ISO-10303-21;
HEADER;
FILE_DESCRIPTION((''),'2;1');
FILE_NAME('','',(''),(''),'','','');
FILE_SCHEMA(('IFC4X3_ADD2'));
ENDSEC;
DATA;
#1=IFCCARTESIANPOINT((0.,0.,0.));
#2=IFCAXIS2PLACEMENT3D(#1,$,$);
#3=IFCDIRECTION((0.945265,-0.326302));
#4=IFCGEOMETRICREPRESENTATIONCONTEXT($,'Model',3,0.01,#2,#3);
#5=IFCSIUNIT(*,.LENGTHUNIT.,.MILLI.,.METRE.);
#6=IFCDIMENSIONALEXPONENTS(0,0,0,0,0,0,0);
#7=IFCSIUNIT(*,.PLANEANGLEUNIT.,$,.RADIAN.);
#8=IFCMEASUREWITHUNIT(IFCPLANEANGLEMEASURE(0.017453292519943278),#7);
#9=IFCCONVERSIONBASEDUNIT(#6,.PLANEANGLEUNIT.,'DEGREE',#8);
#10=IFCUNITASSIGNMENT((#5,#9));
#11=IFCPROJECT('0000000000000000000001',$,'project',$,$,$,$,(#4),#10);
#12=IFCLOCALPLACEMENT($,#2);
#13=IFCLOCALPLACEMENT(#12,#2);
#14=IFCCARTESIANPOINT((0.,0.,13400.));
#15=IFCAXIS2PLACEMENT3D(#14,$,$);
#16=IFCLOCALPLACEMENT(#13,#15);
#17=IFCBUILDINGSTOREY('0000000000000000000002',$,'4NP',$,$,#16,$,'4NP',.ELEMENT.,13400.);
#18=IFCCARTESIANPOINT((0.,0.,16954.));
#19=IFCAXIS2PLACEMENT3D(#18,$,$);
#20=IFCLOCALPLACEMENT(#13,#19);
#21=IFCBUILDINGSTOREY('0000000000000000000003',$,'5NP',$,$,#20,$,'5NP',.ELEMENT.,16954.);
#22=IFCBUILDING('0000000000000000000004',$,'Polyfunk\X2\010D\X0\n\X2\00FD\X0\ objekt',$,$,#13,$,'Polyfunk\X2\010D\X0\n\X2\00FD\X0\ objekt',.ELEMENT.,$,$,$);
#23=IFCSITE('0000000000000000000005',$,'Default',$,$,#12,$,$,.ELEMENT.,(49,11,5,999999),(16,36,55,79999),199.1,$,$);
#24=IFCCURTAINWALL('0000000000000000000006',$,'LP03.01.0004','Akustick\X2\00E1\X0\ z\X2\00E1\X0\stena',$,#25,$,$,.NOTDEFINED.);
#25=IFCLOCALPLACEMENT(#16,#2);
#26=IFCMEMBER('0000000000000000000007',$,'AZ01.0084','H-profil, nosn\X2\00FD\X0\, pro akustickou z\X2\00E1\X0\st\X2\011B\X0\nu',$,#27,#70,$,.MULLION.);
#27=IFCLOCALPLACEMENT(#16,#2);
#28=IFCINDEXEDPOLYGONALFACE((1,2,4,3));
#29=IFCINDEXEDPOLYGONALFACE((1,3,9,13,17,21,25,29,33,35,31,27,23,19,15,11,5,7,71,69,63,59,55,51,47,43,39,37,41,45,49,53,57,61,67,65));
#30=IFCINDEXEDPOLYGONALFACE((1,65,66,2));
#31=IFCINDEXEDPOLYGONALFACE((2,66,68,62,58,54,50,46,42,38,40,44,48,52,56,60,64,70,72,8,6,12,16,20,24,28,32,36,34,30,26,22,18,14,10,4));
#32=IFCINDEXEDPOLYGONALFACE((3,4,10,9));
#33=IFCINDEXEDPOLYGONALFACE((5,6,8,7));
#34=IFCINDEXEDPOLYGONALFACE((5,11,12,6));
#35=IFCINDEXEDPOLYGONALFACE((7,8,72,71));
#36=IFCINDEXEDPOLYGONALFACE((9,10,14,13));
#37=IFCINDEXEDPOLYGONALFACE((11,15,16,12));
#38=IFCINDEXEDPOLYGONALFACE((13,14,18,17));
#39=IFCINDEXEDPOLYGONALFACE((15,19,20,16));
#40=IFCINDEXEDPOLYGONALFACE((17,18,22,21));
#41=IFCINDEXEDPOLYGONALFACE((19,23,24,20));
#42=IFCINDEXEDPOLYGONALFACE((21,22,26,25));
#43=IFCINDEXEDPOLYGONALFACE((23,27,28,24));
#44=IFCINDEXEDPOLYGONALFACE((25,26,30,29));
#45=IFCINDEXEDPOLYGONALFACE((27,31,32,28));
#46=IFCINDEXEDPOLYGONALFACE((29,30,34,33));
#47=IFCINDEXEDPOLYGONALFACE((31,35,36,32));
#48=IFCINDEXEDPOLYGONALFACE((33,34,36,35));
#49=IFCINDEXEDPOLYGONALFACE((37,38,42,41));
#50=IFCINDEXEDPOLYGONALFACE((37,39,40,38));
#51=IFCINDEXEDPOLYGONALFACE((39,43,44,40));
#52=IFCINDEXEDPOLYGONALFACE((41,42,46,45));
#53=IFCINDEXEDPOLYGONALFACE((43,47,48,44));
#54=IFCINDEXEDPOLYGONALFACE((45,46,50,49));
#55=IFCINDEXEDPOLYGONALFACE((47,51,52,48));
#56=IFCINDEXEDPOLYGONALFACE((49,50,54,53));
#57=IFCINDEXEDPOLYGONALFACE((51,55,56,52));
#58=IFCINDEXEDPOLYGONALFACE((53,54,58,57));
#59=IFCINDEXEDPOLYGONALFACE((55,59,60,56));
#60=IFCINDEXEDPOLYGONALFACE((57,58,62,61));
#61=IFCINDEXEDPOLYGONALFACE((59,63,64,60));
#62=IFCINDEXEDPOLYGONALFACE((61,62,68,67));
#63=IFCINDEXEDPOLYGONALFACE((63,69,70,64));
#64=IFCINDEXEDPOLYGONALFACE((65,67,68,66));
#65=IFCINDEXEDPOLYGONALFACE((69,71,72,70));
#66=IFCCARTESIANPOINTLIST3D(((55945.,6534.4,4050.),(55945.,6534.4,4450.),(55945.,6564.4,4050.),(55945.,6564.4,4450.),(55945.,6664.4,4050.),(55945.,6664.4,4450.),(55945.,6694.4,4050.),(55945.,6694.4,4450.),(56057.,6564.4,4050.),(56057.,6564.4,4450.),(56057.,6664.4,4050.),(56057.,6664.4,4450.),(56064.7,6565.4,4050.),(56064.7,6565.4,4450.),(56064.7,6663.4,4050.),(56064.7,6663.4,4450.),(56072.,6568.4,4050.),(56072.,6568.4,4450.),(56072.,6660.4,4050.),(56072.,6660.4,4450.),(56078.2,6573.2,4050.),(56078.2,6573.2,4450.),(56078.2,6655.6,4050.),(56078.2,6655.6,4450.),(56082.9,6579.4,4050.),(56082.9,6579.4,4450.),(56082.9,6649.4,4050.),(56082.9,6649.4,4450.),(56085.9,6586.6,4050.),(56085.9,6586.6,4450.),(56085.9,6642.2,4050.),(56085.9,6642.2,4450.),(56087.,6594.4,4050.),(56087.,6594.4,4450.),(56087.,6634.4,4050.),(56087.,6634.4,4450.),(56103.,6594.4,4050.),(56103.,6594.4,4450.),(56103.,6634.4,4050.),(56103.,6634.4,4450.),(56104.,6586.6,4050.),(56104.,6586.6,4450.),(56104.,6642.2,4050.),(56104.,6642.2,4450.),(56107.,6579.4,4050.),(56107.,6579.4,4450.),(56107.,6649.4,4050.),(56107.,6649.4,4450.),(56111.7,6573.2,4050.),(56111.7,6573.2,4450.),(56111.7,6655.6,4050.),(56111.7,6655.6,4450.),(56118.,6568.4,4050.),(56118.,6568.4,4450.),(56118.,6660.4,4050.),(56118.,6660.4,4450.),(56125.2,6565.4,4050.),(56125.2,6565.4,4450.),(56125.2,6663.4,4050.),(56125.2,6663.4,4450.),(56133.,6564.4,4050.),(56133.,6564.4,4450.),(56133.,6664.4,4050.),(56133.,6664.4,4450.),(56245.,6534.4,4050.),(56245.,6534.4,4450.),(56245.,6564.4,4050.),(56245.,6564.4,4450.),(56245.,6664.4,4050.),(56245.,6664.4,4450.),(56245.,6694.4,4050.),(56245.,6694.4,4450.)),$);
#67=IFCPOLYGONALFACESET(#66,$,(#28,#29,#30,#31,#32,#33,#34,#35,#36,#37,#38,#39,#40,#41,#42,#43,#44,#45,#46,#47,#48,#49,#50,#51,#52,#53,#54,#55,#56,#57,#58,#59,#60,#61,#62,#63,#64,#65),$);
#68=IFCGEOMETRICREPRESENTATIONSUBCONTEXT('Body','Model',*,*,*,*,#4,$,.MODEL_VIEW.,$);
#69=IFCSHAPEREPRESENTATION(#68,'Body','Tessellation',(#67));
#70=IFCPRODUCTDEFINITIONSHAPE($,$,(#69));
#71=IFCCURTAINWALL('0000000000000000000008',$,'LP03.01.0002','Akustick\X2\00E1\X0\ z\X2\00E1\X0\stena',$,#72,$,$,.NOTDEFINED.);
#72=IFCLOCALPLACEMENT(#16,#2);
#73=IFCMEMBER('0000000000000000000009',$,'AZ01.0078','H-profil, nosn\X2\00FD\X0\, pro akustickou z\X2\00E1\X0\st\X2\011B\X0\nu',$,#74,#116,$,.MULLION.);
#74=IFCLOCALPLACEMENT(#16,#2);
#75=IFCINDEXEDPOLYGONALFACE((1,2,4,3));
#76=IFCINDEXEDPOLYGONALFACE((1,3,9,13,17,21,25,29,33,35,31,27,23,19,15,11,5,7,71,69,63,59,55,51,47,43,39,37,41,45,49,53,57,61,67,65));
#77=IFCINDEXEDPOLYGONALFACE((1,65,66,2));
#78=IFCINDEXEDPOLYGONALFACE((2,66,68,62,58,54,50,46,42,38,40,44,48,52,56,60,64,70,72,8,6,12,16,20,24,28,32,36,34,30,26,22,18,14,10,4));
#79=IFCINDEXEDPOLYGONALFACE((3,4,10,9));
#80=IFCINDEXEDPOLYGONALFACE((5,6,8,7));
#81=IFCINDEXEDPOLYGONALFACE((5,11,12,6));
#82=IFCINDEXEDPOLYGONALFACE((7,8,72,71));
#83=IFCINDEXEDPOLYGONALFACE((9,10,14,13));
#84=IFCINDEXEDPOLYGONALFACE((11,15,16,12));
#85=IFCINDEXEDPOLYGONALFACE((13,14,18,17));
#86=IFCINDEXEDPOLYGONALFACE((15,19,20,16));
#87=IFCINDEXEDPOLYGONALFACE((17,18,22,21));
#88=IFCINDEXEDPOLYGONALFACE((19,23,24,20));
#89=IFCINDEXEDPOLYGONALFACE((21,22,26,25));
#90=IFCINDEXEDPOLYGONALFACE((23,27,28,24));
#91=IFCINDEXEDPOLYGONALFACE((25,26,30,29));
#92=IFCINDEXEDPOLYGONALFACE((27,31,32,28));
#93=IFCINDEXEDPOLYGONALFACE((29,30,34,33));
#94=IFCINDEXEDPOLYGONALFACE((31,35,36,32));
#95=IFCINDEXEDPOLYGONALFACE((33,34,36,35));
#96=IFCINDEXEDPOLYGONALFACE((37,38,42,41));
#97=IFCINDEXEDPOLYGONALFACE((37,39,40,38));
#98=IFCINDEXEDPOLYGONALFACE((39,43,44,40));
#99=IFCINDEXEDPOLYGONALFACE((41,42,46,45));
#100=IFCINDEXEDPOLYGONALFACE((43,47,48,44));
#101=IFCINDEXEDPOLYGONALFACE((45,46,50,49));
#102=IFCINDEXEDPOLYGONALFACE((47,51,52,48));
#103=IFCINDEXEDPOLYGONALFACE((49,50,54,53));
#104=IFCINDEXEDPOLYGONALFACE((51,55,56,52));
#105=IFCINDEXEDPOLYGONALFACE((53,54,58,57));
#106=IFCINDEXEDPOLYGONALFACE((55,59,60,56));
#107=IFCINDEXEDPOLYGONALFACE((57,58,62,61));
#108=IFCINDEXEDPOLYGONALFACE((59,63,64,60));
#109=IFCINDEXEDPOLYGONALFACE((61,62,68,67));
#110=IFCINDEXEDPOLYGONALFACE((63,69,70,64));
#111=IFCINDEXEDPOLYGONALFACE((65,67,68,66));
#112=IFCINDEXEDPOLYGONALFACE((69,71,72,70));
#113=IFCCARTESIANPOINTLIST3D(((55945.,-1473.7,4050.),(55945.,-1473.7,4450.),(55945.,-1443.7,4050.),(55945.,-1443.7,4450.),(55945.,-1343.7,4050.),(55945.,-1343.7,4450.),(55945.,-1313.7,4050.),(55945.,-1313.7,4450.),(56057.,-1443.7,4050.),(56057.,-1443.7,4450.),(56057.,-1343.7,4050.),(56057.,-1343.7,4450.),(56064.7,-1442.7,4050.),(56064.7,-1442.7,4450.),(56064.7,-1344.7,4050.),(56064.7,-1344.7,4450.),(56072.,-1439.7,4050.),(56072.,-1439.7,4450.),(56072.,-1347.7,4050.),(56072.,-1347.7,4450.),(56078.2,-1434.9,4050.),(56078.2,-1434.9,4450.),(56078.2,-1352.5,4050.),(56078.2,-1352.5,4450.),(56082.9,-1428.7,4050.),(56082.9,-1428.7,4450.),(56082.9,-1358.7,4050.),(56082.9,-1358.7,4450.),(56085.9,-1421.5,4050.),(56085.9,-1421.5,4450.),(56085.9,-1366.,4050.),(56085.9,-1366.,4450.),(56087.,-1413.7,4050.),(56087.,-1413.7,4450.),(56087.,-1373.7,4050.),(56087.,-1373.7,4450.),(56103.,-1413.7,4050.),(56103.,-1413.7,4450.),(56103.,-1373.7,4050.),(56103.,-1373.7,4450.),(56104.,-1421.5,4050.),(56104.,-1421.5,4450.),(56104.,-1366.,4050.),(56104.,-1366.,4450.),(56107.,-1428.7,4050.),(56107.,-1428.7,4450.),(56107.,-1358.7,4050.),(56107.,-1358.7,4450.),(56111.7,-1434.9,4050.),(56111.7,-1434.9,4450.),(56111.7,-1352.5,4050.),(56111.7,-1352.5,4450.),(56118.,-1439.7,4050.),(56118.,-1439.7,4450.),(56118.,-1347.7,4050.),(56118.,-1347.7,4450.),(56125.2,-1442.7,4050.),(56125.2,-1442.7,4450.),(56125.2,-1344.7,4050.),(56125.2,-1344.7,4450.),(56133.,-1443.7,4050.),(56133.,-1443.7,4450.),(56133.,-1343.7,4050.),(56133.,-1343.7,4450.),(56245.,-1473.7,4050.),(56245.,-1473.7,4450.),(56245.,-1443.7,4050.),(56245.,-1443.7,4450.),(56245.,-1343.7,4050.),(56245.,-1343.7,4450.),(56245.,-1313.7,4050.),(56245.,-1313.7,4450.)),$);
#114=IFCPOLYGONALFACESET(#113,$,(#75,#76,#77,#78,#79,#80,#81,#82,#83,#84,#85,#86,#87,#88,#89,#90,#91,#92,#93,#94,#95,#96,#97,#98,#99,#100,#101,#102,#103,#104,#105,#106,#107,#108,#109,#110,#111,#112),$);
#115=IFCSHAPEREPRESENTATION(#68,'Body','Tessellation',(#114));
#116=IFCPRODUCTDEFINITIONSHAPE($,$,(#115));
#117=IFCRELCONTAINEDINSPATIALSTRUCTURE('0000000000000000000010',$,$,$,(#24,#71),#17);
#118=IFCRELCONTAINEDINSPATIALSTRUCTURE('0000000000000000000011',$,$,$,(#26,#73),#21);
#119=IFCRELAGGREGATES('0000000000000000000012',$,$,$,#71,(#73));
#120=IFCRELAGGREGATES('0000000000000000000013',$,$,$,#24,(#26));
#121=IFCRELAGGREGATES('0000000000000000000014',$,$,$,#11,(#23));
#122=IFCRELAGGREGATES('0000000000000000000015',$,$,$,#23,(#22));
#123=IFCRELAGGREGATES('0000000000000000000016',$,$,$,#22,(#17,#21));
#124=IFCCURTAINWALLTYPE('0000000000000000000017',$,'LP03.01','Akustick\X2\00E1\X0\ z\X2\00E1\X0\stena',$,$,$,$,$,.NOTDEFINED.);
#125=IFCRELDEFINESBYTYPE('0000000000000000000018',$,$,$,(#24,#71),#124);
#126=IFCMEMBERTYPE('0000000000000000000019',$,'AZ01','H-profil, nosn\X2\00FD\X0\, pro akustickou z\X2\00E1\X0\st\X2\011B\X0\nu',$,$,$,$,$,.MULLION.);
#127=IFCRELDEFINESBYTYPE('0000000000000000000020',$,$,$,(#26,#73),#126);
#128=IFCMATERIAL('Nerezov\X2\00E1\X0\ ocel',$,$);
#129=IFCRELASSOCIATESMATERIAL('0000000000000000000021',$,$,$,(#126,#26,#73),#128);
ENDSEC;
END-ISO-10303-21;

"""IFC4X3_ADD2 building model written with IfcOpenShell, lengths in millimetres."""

from ifc_helpers import new_model, entity, si_unit, converted_unit, direction, frame, frame_2d, origin, place, context, subcontext, project, spatial, polyline, circle_curve, parameter, trimmed, segment, composite_curve, outline, extrude, source, transform, mapped, material, material_profile, profile_set, profile_usage, type_object, element, aggregate, save


model = new_model("IFC4X3_ADD2")

# Units and contexts
model_context = context("Model", 3, precision=0.01, world=origin(), true_north=direction((0.945265, -0.326302)))
body_context = subcontext(model_context, "Body", "Model", "MODEL_VIEW")
ifc_project = project(units=[si_unit("LENGTHUNIT", "METRE", prefix="MILLI"), converted_unit("PLANEANGLEUNIT", "DEGREE", entity("IfcPlaneAngleMeasure", 0.017453292519943278), si_unit("PLANEANGLEUNIT", "RADIAN"), dimensions=[0, 0, 0, 0, 0, 0, 0])], contexts=[model_context])

# Site, building, storey
site_placement = place(None, origin())
site = spatial("IfcSite", under=ifc_project, at=site_placement, Name="Default", CompositionType="ELEMENT", RefLatitude=(49, 11, 5, 999999), RefLongitude=(16, 36, 55, 79999), RefElevation=199.1)
building_placement = place(site_placement, origin())
building = spatial("IfcBuilding", under=site, at=building_placement, Name="Polyfunkčný objekt", LongName="Polyfunkčný objekt", CompositionType="ELEMENT")
storey_1_placement = place(building_placement, frame((0.0, 0.0, 13400.0)))
storey_1 = spatial("IfcBuildingStorey", under=building, at=storey_1_placement, Name="4NP", LongName="4NP", CompositionType="ELEMENT", Elevation=13400.0)

# Curtain wall
curtain_wall_type = type_object("IfcCurtainWallType", Name="LP03.01", Description="Akustická zástena", PredefinedType="NOTDEFINED")
curtain_wall_1_placement = place(storey_1_placement, frame((0.0, 0.0, -13400.0)))
curtain_wall_1 = element("IfcCurtainWall", 1, at=curtain_wall_1_placement, inside=storey_1, type_object=curtain_wall_type, Name="LP03.01.0004", Description="Akustická zástena", PredefinedType="NOTDEFINED")

# Shared definitions
storey_2_placement = place(building_placement, frame((0.0, 0.0, 16954.0)))
storey_2 = spatial("IfcBuildingStorey", under=building, at=storey_2_placement, Name="5NP", LongName="5NP", CompositionType="ELEMENT", Elevation=16954.0)

# Shared definitions
ifc_material_1 = material(Name="Nerezová ocel")
ifc_material_profile = material_profile(ifc_material_1, outline(composite_curve([segment(polyline([(50.0, -150.0), (80.0, -150.0)]), True, "CONTINUOUS"), segment(polyline([(80.0, -150.0), (80.0, 150.0)]), True, "CONTINUOUS"), segment(polyline([(80.0, 150.0), (50.0, 150.0)]), True, "CONTINUOUS"), segment(polyline([(50.0, 150.0), (50.0, 38.0)]), True, "CONTINUOUS"), segment(trimmed(circle_curve(frame_2d((20.0, 38.0), x_axis=(0.0, 1.0)), 30.0), [parameter(180.0)], [parameter(270.0)], True, "PARAMETER"), False, "CONTINUOUS"), segment(polyline([(20.0, 8.0), (-20.0, 8.0)]), True, "CONTINUOUS"), segment(trimmed(circle_curve(frame_2d((-20.0, 38.0), x_axis=(0.0, 1.0)), 30.0), [parameter(90.0)], [parameter(180.0)], True, "PARAMETER"), False, "CONTINUOUS"), segment(polyline([(-50.0, 38.0), (-50.0, 150.0)]), True, "CONTINUOUS"), segment(polyline([(-50.0, 150.0), (-80.0, 150.0)]), True, "CONTINUOUS"), segment(polyline([(-80.0, 150.0), (-80.0, -150.0)]), True, "CONTINUOUS"), segment(polyline([(-80.0, -150.0), (-50.0, -150.0)]), True, "CONTINUOUS"), segment(polyline([(-50.0, -150.0), (-50.0, -38.0)]), True, "CONTINUOUS"), segment(trimmed(circle_curve(frame_2d((-20.0, -38.0), x_axis=(0.0, 1.0)), 30.0), [parameter(0.0)], [parameter(90.0)], True, "PARAMETER"), False, "CONTINUOUS"), segment(polyline([(-20.0, -8.0), (20.0, -8.0)]), True, "CONTINUOUS"), segment(trimmed(circle_curve(frame_2d((20.0, -38.0), x_axis=(0.0, 1.0)), 30.0), [parameter(270.0)], [parameter(0.0)], True, "PARAMETER"), False, "CONTINUOUS"), segment(polyline([(50.0, -38.0), (50.0, -150.0)]), True, "CONTINUOUS")], self_intersect=False)), Name="Profil zástena")
ifc_profile_set = profile_set([ifc_material_profile], Name="Profil zástena")
ifc_profile_usage = profile_usage(ifc_profile_set)
member_type = type_object("IfcMemberType", Name="AZ01", Description="H-profil, nosný, pro akustickou zástěnu", PredefinedType="MULLION", material=ifc_profile_set)

# Member
shared_shape_1 = source(origin(), body_context, "Body", "SweptSolid", [
    extrude(outline(composite_curve([segment(polyline([(50.0, -150.0), (80.0, -150.0)]), True, "CONTINUOUS"), segment(polyline([(80.0, -150.0), (80.0, 150.0)]), True, "CONTINUOUS"), segment(polyline([(80.0, 150.0), (50.0, 150.0)]), True, "CONTINUOUS"), segment(polyline([(50.0, 150.0), (50.0, 38.0)]), True, "CONTINUOUS"), segment(trimmed(circle_curve(frame_2d((20.0, 38.0), x_axis=(0.0, 1.0)), 30.0), [parameter(180.0)], [parameter(270.0)], True, "PARAMETER"), False, "CONTINUOUS"), segment(polyline([(20.0, 8.0), (-20.0, 8.0)]), True, "CONTINUOUS"), segment(trimmed(circle_curve(frame_2d((-20.0, 38.0), x_axis=(0.0, 1.0)), 30.0), [parameter(90.0)], [parameter(180.0)], True, "PARAMETER"), False, "CONTINUOUS"), segment(polyline([(-50.0, 38.0), (-50.0, 150.0)]), True, "CONTINUOUS"), segment(polyline([(-50.0, 150.0), (-80.0, 150.0)]), True, "CONTINUOUS"), segment(polyline([(-80.0, 150.0), (-80.0, -150.0)]), True, "CONTINUOUS"), segment(polyline([(-80.0, -150.0), (-50.0, -150.0)]), True, "CONTINUOUS"), segment(polyline([(-50.0, -150.0), (-50.0, -38.0)]), True, "CONTINUOUS"), segment(trimmed(circle_curve(frame_2d((-20.0, -38.0), x_axis=(0.0, 1.0)), 30.0), [parameter(0.0)], [parameter(90.0)], True, "PARAMETER"), False, "CONTINUOUS"), segment(polyline([(-20.0, -8.0), (20.0, -8.0)]), True, "CONTINUOUS"), segment(trimmed(circle_curve(frame_2d((20.0, -38.0), x_axis=(0.0, 1.0)), 30.0), [parameter(270.0)], [parameter(0.0)], True, "PARAMETER"), False, "CONTINUOUS"), segment(polyline([(50.0, -38.0), (50.0, -150.0)]), True, "CONTINUOUS")], self_intersect=False)), frame((-150.0, 0.0, -400.0), z_axis=(0.0, 0.0, 1.0), x_axis=(0.0, -1.0, 0.0)), (0.0, 0.0, 1.0), 400.0),
])
member_1_placement = place(curtain_wall_1_placement, frame((56245.0, 6614.4, 17450.0), z_axis=(0.0, 0.0, -1.0), x_axis=(1.0, 0.0, 0.0)))
member_1 = element("IfcMember", 2, at=member_1_placement, inside=storey_2, type_object=member_type, material=ifc_profile_usage, Name="AZ01.0084", Description="H-profil, nosný, pro akustickou zástěnu", PredefinedType="MULLION", context=body_context, shape_type="MappedRepresentation", body=[
    mapped(shared_shape_1, transform((0.0, 0.0, 0.0), scale=1.0)),
])

# Curtain wall, member
curtain_wall_2_placement = place(storey_1_placement, frame((0.0, 0.0, -13400.0)))
curtain_wall_2 = element("IfcCurtainWall", 3, at=curtain_wall_2_placement, inside=storey_1, type_object=curtain_wall_type, Name="LP03.01.0002", Description="Akustická zástena", PredefinedType="NOTDEFINED")
member_2_placement = place(curtain_wall_2_placement, frame((56245.0, -1393.7, 17450.0), z_axis=(0.0, 0.0, -1.0), x_axis=(1.0, 0.0, 0.0)))
member_2 = element("IfcMember", 4, at=member_2_placement, inside=storey_2, type_object=member_type, material=ifc_profile_usage, Name="AZ01.0078", Description="H-profil, nosný, pro akustickou zástěnu", PredefinedType="MULLION", context=body_context, shape_type="MappedRepresentation", body=[
    mapped(shared_shape_1, transform((0.0, 0.0, 0.0), scale=1.0)),
])
aggregate(curtain_wall_2, [member_2])

aggregate(curtain_wall_1, [member_1])

save(model, "model.ifc")
